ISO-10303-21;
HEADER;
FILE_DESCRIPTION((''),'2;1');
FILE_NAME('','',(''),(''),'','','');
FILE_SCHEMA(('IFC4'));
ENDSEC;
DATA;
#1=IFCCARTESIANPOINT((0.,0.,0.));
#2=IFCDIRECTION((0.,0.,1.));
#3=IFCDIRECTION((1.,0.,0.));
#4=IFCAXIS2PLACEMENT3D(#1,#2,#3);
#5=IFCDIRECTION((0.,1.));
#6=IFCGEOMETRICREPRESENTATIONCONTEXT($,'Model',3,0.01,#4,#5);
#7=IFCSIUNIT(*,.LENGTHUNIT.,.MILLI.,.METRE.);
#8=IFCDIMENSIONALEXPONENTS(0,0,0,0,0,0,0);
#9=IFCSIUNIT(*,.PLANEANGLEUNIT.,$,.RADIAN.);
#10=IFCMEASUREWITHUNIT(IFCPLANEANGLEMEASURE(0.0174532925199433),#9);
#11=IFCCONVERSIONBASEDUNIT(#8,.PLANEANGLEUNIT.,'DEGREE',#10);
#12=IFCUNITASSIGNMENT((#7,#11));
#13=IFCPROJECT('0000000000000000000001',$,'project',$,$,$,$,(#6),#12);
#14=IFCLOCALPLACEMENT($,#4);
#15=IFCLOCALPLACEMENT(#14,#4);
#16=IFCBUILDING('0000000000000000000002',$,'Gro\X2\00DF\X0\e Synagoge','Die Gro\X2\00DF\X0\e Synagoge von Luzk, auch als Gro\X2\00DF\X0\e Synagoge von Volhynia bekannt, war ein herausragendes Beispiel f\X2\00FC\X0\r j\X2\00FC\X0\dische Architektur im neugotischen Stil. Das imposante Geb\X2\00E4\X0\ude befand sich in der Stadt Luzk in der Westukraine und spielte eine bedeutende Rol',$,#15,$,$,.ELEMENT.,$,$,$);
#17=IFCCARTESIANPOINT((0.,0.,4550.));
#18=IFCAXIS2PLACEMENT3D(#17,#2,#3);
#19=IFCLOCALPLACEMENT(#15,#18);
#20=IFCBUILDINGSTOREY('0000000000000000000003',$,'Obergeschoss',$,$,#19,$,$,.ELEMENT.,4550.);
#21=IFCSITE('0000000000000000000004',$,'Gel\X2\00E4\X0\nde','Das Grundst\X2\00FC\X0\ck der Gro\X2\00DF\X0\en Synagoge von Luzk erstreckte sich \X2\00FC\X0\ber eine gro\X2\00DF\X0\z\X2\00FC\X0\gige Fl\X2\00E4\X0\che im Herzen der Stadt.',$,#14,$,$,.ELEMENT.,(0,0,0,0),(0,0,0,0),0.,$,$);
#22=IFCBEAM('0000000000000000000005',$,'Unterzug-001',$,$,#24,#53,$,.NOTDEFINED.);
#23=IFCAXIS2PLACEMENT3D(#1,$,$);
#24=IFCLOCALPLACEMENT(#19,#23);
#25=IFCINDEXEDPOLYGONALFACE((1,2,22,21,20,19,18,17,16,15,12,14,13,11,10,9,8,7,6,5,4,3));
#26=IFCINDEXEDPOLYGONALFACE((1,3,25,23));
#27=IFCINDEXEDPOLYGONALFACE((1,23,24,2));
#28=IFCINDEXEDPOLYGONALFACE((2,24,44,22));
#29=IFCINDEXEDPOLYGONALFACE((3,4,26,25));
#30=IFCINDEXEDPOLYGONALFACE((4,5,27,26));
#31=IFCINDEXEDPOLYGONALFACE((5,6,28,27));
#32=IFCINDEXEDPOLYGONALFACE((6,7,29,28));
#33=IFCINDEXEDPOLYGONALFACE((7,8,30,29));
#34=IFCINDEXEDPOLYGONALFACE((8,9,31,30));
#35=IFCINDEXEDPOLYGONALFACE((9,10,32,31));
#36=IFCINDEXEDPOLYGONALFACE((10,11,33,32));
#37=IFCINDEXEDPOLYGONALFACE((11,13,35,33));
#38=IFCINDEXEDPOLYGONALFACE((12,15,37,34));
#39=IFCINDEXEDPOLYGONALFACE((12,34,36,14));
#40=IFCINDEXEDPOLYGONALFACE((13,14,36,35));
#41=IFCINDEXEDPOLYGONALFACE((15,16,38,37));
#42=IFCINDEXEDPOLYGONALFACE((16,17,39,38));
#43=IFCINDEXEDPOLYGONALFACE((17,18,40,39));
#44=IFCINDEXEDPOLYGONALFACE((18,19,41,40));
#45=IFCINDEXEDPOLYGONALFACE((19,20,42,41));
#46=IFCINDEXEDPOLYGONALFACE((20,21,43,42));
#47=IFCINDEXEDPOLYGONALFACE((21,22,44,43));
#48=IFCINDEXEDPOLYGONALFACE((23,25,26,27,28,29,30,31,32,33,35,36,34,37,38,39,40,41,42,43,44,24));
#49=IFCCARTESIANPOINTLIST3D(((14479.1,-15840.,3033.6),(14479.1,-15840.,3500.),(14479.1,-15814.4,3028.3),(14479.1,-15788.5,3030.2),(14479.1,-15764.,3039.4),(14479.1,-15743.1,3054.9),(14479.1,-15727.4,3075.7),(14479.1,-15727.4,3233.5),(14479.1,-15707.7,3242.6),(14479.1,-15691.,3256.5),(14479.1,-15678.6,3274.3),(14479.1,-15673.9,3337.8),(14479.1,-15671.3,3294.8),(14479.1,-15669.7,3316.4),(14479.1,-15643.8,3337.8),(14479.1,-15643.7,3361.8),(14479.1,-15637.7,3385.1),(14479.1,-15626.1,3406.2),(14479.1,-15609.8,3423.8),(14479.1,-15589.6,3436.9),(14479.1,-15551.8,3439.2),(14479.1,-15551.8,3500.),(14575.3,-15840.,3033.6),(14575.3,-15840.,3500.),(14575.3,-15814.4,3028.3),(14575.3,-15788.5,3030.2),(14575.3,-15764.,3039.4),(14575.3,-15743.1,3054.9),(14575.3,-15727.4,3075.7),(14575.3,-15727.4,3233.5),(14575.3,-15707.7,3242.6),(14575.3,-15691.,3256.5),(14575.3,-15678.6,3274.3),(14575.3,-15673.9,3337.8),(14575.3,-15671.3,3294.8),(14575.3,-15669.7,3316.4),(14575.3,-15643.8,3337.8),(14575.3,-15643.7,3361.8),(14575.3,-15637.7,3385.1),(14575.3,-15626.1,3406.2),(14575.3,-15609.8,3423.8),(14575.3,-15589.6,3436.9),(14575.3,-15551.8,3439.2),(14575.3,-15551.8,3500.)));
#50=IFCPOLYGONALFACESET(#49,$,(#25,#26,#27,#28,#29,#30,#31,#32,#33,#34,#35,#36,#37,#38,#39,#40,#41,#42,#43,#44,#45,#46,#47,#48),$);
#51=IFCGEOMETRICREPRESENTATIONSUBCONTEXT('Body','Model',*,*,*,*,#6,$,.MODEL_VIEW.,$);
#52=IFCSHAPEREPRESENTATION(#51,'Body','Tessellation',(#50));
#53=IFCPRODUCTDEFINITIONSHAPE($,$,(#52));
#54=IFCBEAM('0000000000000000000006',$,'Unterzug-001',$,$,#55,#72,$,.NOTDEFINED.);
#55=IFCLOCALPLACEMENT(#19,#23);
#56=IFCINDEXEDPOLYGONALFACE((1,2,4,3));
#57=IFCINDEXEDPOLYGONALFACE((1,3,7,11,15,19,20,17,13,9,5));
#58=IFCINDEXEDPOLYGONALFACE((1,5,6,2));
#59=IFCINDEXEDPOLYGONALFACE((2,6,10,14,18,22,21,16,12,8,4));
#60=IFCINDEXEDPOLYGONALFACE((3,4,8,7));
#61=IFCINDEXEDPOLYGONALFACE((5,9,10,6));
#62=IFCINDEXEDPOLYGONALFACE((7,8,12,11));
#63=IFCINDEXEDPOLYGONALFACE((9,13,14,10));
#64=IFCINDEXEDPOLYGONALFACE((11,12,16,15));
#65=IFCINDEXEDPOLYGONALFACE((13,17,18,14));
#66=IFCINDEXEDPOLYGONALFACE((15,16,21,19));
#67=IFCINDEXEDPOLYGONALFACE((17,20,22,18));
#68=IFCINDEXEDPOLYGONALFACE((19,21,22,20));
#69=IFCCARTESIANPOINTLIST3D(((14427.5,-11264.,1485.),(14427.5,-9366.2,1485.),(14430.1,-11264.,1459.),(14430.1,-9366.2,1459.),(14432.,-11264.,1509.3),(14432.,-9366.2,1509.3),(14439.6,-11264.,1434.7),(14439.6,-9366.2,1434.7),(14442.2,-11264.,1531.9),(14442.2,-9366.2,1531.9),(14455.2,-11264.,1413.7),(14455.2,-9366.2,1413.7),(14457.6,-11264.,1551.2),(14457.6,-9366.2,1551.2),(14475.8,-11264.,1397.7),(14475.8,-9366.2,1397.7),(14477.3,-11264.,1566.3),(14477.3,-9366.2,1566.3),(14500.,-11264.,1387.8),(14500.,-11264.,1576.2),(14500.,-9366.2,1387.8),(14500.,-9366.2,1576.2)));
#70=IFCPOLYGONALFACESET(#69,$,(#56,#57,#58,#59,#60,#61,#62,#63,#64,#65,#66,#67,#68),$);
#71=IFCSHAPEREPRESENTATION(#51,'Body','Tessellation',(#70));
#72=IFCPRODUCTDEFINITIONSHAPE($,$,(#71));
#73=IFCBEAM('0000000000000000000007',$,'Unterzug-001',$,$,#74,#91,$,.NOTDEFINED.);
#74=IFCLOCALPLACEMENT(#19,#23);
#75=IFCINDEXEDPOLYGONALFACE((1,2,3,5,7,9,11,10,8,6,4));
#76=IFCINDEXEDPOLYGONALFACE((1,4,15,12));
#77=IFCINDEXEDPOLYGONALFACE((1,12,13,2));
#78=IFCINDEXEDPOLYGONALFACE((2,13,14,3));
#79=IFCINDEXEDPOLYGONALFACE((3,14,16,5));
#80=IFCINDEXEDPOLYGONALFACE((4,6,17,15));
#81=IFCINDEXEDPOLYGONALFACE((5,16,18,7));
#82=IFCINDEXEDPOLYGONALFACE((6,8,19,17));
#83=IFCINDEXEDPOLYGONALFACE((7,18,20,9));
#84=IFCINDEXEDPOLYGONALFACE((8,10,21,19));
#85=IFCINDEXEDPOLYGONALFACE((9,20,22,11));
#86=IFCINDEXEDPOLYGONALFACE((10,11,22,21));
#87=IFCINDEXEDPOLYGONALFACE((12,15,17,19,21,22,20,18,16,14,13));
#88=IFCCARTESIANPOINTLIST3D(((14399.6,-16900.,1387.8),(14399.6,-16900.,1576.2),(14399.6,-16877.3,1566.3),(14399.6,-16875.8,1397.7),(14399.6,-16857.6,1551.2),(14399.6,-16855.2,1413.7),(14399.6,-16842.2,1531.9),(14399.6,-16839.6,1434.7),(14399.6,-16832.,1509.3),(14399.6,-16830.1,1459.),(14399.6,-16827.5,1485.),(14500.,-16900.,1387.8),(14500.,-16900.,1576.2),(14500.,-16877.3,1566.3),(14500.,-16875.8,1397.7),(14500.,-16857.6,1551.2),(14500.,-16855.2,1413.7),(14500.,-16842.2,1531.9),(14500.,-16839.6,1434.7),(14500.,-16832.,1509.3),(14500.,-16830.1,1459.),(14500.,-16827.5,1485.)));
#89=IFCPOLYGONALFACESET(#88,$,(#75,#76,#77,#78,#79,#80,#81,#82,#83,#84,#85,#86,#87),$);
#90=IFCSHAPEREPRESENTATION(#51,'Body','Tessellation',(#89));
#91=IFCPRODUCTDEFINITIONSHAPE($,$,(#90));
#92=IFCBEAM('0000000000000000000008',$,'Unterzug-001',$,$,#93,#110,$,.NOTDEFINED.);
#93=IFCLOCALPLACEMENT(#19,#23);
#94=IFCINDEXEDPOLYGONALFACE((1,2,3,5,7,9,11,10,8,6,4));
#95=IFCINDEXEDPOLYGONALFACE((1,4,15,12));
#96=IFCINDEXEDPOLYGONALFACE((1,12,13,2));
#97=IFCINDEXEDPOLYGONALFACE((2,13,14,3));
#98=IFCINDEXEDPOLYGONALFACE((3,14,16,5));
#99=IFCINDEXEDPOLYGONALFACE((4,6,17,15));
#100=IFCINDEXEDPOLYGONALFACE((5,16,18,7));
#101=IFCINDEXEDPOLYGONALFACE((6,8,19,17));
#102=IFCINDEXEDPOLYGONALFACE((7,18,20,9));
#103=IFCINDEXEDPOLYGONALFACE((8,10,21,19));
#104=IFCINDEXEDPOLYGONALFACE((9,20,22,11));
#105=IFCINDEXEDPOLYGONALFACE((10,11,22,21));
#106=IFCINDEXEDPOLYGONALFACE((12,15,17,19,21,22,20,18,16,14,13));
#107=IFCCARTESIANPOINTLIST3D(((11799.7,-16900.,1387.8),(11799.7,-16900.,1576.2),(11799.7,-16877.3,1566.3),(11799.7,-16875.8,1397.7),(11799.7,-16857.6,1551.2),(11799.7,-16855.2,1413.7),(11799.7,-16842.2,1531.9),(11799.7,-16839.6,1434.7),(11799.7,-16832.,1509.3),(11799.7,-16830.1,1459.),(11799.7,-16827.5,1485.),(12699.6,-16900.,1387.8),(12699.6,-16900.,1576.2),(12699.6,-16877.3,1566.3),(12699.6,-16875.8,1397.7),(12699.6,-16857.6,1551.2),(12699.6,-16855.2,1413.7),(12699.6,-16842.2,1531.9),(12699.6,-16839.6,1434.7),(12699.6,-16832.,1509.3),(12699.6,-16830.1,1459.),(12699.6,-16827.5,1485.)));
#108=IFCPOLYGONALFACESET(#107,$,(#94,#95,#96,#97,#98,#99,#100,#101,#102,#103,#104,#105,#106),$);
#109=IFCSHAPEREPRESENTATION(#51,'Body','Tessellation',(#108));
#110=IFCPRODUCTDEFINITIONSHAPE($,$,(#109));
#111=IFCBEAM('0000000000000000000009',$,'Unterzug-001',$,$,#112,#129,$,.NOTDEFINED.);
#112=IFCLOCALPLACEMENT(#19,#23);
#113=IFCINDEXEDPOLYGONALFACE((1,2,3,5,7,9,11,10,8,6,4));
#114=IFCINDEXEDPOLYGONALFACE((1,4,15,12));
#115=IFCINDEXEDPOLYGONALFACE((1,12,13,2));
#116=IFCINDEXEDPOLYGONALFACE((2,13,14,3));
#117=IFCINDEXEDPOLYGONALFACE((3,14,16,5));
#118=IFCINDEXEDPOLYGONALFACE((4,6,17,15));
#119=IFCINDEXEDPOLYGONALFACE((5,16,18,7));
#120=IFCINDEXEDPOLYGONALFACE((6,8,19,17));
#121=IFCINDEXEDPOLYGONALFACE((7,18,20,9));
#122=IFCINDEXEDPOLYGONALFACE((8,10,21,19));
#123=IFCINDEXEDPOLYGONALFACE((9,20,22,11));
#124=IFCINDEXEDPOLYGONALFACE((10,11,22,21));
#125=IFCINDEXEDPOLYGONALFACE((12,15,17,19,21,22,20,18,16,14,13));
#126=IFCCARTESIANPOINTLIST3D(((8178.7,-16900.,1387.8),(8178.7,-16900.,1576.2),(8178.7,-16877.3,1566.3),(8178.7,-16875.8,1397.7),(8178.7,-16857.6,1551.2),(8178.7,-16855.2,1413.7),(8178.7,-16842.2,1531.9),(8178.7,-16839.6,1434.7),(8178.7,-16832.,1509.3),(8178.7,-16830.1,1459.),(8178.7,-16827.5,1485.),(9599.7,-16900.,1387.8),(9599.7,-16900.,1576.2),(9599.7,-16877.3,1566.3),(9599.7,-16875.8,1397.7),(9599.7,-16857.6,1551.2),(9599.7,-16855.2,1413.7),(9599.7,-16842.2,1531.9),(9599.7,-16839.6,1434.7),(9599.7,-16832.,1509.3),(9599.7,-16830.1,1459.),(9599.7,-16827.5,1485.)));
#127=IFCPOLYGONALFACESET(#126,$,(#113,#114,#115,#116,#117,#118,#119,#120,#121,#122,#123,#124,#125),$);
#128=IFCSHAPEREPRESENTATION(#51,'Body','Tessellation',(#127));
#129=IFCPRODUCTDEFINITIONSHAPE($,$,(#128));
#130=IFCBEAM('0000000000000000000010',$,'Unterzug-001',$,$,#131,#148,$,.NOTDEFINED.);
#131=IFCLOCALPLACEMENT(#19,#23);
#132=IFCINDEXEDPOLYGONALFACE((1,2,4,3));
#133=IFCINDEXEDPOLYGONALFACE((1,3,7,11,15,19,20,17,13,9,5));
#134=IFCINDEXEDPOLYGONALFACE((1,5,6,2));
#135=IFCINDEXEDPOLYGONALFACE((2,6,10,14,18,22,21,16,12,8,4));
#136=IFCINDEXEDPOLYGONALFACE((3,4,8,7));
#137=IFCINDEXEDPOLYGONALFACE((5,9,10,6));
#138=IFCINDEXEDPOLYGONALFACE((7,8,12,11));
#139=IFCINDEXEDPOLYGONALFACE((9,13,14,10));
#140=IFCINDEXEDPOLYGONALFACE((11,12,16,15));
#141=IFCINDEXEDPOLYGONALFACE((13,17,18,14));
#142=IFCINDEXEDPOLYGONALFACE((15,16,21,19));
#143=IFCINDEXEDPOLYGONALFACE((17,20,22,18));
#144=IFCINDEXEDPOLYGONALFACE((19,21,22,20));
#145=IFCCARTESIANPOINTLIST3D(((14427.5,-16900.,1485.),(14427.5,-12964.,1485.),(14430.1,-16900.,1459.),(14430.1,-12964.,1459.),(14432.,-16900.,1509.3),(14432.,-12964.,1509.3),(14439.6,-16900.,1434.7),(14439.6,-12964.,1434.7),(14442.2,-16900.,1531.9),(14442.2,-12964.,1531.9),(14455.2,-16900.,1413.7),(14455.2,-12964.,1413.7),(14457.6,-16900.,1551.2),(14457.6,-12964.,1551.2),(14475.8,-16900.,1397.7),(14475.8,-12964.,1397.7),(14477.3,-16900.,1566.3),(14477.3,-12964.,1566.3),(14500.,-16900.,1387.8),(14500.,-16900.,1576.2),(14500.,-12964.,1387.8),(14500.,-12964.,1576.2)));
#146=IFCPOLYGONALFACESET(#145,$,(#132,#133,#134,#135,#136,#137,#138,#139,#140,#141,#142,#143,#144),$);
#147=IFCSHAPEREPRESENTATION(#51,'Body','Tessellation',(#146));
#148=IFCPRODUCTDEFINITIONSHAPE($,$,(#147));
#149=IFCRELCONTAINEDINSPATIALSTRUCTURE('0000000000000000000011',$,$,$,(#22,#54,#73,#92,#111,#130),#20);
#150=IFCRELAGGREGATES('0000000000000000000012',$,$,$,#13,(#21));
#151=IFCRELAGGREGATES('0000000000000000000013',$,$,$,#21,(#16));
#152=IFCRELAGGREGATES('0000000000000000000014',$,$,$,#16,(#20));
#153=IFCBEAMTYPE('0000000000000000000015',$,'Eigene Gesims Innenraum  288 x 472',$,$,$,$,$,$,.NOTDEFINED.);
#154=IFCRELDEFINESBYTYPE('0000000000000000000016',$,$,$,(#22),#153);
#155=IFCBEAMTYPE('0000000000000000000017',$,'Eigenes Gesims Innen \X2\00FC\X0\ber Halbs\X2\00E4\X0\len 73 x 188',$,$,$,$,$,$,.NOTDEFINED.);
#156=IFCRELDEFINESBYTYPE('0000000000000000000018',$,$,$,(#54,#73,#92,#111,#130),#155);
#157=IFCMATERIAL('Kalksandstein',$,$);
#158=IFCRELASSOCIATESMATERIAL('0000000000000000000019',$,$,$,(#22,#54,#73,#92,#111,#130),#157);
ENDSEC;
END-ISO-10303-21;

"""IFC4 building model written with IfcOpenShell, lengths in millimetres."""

from ifc_helpers import new_model, entity, si_unit, converted_unit, direction, frame, origin_with_axes, place, context, subcontext, project, spatial, line, arc, indexed_curve, outline, extrude, material, material_profile, profile_set, type_object, element, save


model = new_model("IFC4")

# Units and contexts
model_context = context("Model", 3, precision=0.01, world=origin_with_axes(), true_north=direction((0.0, 1.0)))
body_context = subcontext(model_context, "Body", "Model", "MODEL_VIEW")
ifc_project = project(units=[si_unit("LENGTHUNIT", "METRE", prefix="MILLI"), converted_unit("PLANEANGLEUNIT", "DEGREE", entity("IfcPlaneAngleMeasure", 0.0174532925199433), si_unit("PLANEANGLEUNIT", "RADIAN"), dimensions=[0, 0, 0, 0, 0, 0, 0])], contexts=[model_context])

# Site, building, storey
site_placement = place(None, origin_with_axes())
site = spatial("IfcSite", under=ifc_project, at=site_placement, Name="Gelände", Description="Das Grundstück der Großen Synagoge von Luzk erstreckte sich über eine großzügige Fläche im Herzen der Stadt.", CompositionType="ELEMENT", RefLatitude=(0, 0, 0, 0), RefLongitude=(0, 0, 0, 0), RefElevation=0.0)
building_placement = place(site_placement, origin_with_axes())
building = spatial("IfcBuilding", under=site, at=building_placement, Name="Große Synagoge", Description="Die Große Synagoge von Luzk, auch als Große Synagoge von Volhynia bekannt, war ein herausragendes Beispiel für jüdische Architektur im neugotischen Stil. Das imposante Gebäude befand sich in der Stadt Luzk in der Westukraine und spielte eine bedeutende Rol", CompositionType="ELEMENT")
storey_placement = place(building_placement, frame((0.0, 0.0, 4550.0), z_axis=(0.0, 0.0, 1.0), x_axis=(1.0, 0.0, 0.0)))
storey = spatial("IfcBuildingStorey", under=building, at=storey_placement, Name="Obergeschoss", CompositionType="ELEMENT", Elevation=4550.0)

# Beams
ifc_material_1 = material(Name="Kalksandstein")
ifc_material_profile_1 = material_profile(ifc_material_1, outline(indexed_curve([(0.0, 0.0), (0.0, -466.4), (64.0, -466.1), (112.6, -424.3), (112.6, -266.5), (161.4, -225.7), (166.1, -162.2), (196.1, -162.2), (207.4, -104.0), (250.4, -63.1), (288.2, -60.8), (288.2, 0.0)], segments=[line(1, 2), arc(2, 3, 4), line(4, 5), arc(5, 6, 7), line(7, 8), arc(8, 9, 10), line(10, 11, 12, 1)])), Name="Kalksandstein")
ifc_profile_set_1 = profile_set([ifc_material_profile_1], Name="Eigene Gesims Innenraum ")
beam_type_1 = type_object("IfcBeamType", Name="Eigene Gesims Innenraum  288 x 472", PredefinedType="NOTDEFINED")
beam_1_placement = place(storey_placement, frame((14479.1, -15840.0, 3500.0), z_axis=(0.0, 0.0, 1.0), x_axis=(0.0, -1.0, 0.0)))
element("IfcBeam", 1, at=beam_1_placement, inside=storey, type_object=beam_type_1, material=ifc_profile_set_1, Name="Unterzug-001", PredefinedType="NOTDEFINED", context=body_context, shape_type="SweptSolid", body=[
    extrude(outline(indexed_curve([(0.0, 0.0), (0.0, -466.4), (64.0, -466.1), (112.6, -424.3), (112.6, -266.5), (161.4, -225.7), (166.1, -162.2), (196.1, -162.2), (207.4, -104.0), (250.4, -63.1), (288.2, -60.8), (288.2, 0.0)], segments=[line(1, 2), arc(2, 3, 4), line(4, 5), arc(5, 6, 7), line(7, 8), arc(8, 9, 10), line(10, 11, 12, 1)])), frame((0.0, 96.3, 0.0), z_axis=(0.0, 1.0, 0.0), x_axis=(-1.0, 0.0, 0.0)), (0.0, 0.0, -1.0), 96.3),
])
ifc_material_profile_2 = material_profile(ifc_material_1, outline(indexed_curve([(72.5, -91.2), (50.7, -34.1), (0.0, 0.0), (0.0, -188.3), (53.3, -152.5)], segments=[arc(1, 2, 3), line(3, 4), arc(4, 5, 1)])), Name="Kalksandstein")
ifc_profile_set_2 = profile_set([ifc_material_profile_2], Name="Eigenes Gesims Innen über Halbsälen")
beam_type_2 = type_object("IfcBeamType", Name="Eigenes Gesims Innen über Halbsälen 73 x 188", PredefinedType="NOTDEFINED")
beam_2_placement = place(storey_placement, frame((14500.0, -11264.0, 1576.2), z_axis=(0.0, 0.0, 1.0), x_axis=(1.0, 0.0, 0.0)))
element("IfcBeam", 2, at=beam_2_placement, inside=storey, type_object=beam_type_2, material=ifc_profile_set_2, Name="Unterzug-001", PredefinedType="NOTDEFINED", context=body_context, shape_type="SweptSolid", body=[
    extrude(outline(indexed_curve([(72.5, -91.2), (50.7, -34.1), (0.0, 0.0), (0.0, -188.3), (53.3, -152.5)], segments=[arc(1, 2, 3), line(3, 4), arc(4, 5, 1)])), frame((0.0, 1897.9, 0.0), z_axis=(0.0, 1.0, 0.0), x_axis=(-1.0, 0.0, 0.0)), (0.0, 0.0, -1.0), 1897.9),
])
beam_3_placement = place(storey_placement, frame((14399.6, -16900.0, 1576.2), z_axis=(0.0, 0.0, 1.0), x_axis=(0.0, -1.0, 0.0)))
element("IfcBeam", 3, at=beam_3_placement, inside=storey, type_object=beam_type_2, material=ifc_profile_set_2, Name="Unterzug-001", PredefinedType="NOTDEFINED", context=body_context, shape_type="SweptSolid", body=[
    extrude(outline(indexed_curve([(72.5, -91.2), (50.7, -34.1), (0.0, 0.0), (0.0, -188.3), (53.3, -152.5)], segments=[arc(1, 2, 3), line(3, 4), arc(4, 5, 1)])), frame((0.0, 100.4, 0.0), z_axis=(0.0, 1.0, 0.0), x_axis=(-1.0, 0.0, 0.0)), (0.0, 0.0, -1.0), 100.4),
])
beam_4_placement = place(storey_placement, frame((11799.7, -16900.0, 1576.2), z_axis=(0.0, 0.0, 1.0), x_axis=(0.0, -1.0, 0.0)))
element("IfcBeam", 4, at=beam_4_placement, inside=storey, type_object=beam_type_2, material=ifc_profile_set_2, Name="Unterzug-001", PredefinedType="NOTDEFINED", context=body_context, shape_type="SweptSolid", body=[
    extrude(outline(indexed_curve([(72.5, -91.2), (50.7, -34.1), (0.0, 0.0), (0.0, -188.3), (53.3, -152.5)], segments=[arc(1, 2, 3), line(3, 4), arc(4, 5, 1)])), frame((0.0, 899.9, 0.0), z_axis=(0.0, 1.0, 0.0), x_axis=(-1.0, 0.0, 0.0)), (0.0, 0.0, -1.0), 899.9),
])
beam_5_placement = place(storey_placement, frame((8178.7, -16900.0, 1576.2), z_axis=(0.0, 0.0, 1.0), x_axis=(0.0, -1.0, 0.0)))
element("IfcBeam", 5, at=beam_5_placement, inside=storey, type_object=beam_type_2, material=ifc_profile_set_2, Name="Unterzug-001", PredefinedType="NOTDEFINED", context=body_context, shape_type="SweptSolid", body=[
    extrude(outline(indexed_curve([(72.5, -91.2), (50.7, -34.1), (0.0, 0.0), (0.0, -188.3), (53.3, -152.5)], segments=[arc(1, 2, 3), line(3, 4), arc(4, 5, 1)])), frame((0.0, 1421.0, 0.0), z_axis=(0.0, 1.0, 0.0), x_axis=(-1.0, 0.0, 0.0)), (0.0, 0.0, -1.0), 1421.0),
])
beam_6_placement = place(storey_placement, frame((14500.0, -16900.0, 1576.2), z_axis=(0.0, 0.0, 1.0), x_axis=(1.0, 0.0, 0.0)))
element("IfcBeam", 6, at=beam_6_placement, inside=storey, type_object=beam_type_2, material=ifc_profile_set_2, Name="Unterzug-001", PredefinedType="NOTDEFINED", context=body_context, shape_type="SweptSolid", body=[
    extrude(outline(indexed_curve([(72.5, -91.2), (50.7, -34.1), (0.0, 0.0), (0.0, -188.3), (53.3, -152.5)], segments=[arc(1, 2, 3), line(3, 4), arc(4, 5, 1)])), frame((0.0, 3936.0, 0.0), z_axis=(0.0, 1.0, 0.0), x_axis=(-1.0, 0.0, 0.0)), (0.0, 0.0, -1.0), 3936.0),
])

save(model, "model.ifc")
